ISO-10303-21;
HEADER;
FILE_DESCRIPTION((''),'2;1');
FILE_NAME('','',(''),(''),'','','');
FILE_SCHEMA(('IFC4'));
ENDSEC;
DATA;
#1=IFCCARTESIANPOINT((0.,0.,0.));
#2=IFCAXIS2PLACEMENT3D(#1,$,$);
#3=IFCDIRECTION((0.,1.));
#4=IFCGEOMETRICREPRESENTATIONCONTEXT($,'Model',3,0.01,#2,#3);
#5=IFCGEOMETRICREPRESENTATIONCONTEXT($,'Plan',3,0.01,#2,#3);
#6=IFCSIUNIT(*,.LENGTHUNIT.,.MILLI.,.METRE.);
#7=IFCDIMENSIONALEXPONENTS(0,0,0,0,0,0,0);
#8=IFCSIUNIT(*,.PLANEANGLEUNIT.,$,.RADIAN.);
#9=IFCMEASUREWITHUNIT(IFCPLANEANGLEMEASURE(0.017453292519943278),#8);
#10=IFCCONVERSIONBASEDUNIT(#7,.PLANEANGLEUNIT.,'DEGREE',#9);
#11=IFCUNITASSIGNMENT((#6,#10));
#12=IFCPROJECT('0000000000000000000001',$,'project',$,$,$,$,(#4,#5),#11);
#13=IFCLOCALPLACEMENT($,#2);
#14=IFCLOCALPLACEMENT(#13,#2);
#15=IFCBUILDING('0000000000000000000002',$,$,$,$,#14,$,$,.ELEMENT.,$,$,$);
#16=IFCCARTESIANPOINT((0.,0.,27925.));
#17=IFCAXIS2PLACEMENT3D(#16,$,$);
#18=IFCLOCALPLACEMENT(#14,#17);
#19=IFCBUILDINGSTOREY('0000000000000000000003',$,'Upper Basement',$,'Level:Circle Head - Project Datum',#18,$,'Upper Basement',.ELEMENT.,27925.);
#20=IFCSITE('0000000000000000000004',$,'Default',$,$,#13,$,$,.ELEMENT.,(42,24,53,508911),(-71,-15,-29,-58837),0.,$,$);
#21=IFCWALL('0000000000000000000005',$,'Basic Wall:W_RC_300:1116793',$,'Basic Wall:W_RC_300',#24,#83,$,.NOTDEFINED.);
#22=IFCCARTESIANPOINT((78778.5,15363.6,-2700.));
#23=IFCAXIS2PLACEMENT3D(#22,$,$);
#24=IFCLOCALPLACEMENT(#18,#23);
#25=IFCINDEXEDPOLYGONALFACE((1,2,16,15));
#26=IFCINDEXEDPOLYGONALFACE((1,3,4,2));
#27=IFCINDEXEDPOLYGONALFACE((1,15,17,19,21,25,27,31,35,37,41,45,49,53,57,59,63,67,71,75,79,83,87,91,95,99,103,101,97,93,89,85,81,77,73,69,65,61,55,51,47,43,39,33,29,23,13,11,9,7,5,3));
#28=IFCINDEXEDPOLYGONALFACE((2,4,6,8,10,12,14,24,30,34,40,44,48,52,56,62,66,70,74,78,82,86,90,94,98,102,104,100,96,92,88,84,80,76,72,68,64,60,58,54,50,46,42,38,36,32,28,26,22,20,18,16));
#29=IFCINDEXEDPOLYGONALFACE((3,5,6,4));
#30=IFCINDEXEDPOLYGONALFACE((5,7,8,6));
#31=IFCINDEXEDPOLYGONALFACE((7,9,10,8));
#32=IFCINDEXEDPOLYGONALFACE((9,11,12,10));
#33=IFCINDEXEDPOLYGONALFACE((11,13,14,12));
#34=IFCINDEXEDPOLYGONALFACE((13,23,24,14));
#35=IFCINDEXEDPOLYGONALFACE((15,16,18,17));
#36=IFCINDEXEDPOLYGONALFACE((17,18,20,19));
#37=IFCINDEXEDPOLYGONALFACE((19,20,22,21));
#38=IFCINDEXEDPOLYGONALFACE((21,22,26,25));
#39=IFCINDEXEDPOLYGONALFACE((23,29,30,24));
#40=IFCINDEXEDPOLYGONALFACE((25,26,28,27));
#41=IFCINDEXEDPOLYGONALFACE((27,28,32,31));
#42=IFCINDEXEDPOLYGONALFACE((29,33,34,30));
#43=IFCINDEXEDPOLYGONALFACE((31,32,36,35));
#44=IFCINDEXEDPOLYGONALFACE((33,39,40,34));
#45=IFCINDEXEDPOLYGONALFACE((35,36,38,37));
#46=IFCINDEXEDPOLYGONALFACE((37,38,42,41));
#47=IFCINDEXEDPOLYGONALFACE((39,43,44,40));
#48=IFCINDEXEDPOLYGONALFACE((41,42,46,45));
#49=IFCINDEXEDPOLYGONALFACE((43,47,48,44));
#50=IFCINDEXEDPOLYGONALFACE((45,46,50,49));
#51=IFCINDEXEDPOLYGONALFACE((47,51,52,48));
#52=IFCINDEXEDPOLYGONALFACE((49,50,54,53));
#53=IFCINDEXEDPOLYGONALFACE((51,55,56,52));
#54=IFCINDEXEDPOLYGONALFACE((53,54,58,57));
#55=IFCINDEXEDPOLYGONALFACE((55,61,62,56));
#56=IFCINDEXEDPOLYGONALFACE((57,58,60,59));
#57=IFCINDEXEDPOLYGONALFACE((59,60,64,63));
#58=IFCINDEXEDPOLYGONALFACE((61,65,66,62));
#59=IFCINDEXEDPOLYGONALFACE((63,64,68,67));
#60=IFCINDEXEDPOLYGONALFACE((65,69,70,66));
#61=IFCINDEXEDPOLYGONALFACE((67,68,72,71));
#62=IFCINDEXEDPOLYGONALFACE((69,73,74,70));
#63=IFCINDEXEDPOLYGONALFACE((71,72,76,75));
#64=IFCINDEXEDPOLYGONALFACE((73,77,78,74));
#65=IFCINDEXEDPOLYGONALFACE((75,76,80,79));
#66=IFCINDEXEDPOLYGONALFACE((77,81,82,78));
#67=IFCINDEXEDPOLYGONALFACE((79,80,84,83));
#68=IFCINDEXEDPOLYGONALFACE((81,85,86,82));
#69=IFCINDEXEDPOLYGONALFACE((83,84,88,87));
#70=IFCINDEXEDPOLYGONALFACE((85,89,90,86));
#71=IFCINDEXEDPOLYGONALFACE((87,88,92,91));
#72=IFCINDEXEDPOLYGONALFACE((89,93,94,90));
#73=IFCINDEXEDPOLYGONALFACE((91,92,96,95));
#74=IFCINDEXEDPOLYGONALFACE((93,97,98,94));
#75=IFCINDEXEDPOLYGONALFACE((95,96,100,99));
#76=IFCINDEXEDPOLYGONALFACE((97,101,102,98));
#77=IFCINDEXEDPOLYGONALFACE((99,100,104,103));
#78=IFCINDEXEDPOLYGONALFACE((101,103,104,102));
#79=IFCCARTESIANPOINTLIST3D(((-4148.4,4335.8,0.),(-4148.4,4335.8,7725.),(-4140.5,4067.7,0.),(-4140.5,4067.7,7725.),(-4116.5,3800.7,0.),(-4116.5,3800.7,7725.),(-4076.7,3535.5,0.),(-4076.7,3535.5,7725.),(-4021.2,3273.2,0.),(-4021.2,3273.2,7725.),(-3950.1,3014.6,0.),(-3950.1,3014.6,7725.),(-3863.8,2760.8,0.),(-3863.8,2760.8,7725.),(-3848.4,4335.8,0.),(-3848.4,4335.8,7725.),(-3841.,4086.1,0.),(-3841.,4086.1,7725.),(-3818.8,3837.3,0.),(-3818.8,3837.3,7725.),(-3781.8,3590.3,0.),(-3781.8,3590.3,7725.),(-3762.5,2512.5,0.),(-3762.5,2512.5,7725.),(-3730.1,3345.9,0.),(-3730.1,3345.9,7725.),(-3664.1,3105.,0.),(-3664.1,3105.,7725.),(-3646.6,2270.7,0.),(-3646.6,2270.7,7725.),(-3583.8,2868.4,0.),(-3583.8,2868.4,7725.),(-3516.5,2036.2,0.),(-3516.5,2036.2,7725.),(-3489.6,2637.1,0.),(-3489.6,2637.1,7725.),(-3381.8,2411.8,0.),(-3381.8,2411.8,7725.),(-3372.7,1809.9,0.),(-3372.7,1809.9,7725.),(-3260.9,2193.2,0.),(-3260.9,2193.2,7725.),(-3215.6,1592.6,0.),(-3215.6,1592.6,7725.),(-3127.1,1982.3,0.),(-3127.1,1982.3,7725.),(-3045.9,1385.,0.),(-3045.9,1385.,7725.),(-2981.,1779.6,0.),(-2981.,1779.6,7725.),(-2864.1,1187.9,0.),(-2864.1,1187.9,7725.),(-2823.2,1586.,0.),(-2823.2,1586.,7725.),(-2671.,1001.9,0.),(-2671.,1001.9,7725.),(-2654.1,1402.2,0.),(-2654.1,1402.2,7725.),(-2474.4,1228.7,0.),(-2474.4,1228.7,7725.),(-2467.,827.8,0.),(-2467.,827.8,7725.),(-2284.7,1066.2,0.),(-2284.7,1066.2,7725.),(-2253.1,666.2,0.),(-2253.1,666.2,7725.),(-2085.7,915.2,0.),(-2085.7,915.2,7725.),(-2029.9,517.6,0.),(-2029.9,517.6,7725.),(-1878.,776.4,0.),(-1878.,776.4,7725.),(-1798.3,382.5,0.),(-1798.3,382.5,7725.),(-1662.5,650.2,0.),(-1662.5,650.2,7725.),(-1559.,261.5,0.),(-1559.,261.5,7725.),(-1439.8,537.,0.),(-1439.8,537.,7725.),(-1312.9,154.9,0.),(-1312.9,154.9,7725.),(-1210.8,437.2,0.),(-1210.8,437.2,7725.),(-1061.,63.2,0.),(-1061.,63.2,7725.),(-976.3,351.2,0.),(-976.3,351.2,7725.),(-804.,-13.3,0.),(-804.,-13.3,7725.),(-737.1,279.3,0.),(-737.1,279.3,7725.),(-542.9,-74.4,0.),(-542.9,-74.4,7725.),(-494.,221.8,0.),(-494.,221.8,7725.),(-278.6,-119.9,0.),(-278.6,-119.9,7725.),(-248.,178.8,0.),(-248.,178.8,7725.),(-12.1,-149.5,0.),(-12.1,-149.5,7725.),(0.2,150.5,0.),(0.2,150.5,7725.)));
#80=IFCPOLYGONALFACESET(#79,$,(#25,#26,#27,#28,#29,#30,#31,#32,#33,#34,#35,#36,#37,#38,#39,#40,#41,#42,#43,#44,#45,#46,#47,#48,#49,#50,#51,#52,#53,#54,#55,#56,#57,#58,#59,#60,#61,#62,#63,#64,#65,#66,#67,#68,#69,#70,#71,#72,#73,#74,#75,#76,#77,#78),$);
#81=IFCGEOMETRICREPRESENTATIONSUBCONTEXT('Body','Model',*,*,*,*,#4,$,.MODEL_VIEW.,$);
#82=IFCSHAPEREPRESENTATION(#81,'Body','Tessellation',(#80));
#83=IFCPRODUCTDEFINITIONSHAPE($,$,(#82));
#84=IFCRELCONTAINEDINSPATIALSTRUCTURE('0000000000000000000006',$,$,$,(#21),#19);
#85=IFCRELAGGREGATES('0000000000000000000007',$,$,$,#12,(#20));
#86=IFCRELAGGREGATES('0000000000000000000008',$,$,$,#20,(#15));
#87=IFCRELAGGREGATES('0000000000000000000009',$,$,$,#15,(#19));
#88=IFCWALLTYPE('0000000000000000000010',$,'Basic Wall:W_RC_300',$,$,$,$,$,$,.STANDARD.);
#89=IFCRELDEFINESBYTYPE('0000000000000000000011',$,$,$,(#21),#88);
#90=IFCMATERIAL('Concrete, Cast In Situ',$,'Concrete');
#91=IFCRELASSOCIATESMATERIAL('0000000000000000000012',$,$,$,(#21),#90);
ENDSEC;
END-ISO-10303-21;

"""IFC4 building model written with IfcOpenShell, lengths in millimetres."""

from ifc_helpers import new_model, entity, si_unit, converted_unit, direction, frame, origin, place, context, subcontext, project, spatial, line, arc, indexed_curve, outline, extrude, material, type_object, element, save


model = new_model("IFC4")

# Units and contexts
model_context = context("Model", 3, precision=0.01, world=origin(), true_north=direction((0.0, 1.0)))
plan_context = context("Plan", 3, precision=0.01, world=origin(), true_north=direction((0.0, 1.0)))
body_context = subcontext(model_context, "Body", "Model", "MODEL_VIEW")
ifc_project = project(units=[si_unit("LENGTHUNIT", "METRE", prefix="MILLI"), converted_unit("PLANEANGLEUNIT", "DEGREE", entity("IfcPlaneAngleMeasure", 0.017453292519943278), si_unit("PLANEANGLEUNIT", "RADIAN"), dimensions=[0, 0, 0, 0, 0, 0, 0])], contexts=[model_context, plan_context])

# Site, building, storey
site_placement = place(None, origin())
site = spatial("IfcSite", under=ifc_project, at=site_placement, Name="Default", CompositionType="ELEMENT", RefLatitude=(42, 24, 53, 508911), RefLongitude=(-71, -15, -29, -58837), RefElevation=0.0)
building_placement = place(site_placement, origin())
building = spatial("IfcBuilding", under=site, at=building_placement, CompositionType="ELEMENT")
storey_placement = place(building_placement, frame((0.0, 0.0, 27925.0)))
storey = spatial("IfcBuildingStorey", under=building, at=storey_placement, Name="Upper Basement", ObjectType="Level:Circle Head - Project Datum", LongName="Upper Basement", CompositionType="ELEMENT", Elevation=27925.0)

# Wall
ifc_material_1 = material(Name="Concrete, Cast In Situ", Category="Concrete")
wall_type = type_object("IfcWallType", Name="Basic Wall:W_RC_300", PredefinedType="STANDARD")
wall_1_placement = place(storey_placement, frame((78778.5, 15363.6, -2700.0)))
element("IfcWall", 1, at=wall_1_placement, inside=storey, type_object=wall_type, material=ifc_material_1, Name="Basic Wall:W_RC_300:1116793", ObjectType="Basic Wall:W_RC_300", PredefinedType="NOTDEFINED", context=body_context, shape_type="SweptSolid", body=[
    extrude(outline(indexed_curve([(-4148.4, 4335.8), (-2956.5, 1285.1), (-12.1, -149.5), (0.2, 150.5), (-2740.0, 1492.8), (-3848.4, 4335.8)], segments=[arc(1, 2, 3), line(3, 4), arc(4, 5, 6), line(6, 1)], self_intersect=False)), origin(), (0.0, 0.0, 1.0), 7725.0),
])

save(model, "model.ifc")
